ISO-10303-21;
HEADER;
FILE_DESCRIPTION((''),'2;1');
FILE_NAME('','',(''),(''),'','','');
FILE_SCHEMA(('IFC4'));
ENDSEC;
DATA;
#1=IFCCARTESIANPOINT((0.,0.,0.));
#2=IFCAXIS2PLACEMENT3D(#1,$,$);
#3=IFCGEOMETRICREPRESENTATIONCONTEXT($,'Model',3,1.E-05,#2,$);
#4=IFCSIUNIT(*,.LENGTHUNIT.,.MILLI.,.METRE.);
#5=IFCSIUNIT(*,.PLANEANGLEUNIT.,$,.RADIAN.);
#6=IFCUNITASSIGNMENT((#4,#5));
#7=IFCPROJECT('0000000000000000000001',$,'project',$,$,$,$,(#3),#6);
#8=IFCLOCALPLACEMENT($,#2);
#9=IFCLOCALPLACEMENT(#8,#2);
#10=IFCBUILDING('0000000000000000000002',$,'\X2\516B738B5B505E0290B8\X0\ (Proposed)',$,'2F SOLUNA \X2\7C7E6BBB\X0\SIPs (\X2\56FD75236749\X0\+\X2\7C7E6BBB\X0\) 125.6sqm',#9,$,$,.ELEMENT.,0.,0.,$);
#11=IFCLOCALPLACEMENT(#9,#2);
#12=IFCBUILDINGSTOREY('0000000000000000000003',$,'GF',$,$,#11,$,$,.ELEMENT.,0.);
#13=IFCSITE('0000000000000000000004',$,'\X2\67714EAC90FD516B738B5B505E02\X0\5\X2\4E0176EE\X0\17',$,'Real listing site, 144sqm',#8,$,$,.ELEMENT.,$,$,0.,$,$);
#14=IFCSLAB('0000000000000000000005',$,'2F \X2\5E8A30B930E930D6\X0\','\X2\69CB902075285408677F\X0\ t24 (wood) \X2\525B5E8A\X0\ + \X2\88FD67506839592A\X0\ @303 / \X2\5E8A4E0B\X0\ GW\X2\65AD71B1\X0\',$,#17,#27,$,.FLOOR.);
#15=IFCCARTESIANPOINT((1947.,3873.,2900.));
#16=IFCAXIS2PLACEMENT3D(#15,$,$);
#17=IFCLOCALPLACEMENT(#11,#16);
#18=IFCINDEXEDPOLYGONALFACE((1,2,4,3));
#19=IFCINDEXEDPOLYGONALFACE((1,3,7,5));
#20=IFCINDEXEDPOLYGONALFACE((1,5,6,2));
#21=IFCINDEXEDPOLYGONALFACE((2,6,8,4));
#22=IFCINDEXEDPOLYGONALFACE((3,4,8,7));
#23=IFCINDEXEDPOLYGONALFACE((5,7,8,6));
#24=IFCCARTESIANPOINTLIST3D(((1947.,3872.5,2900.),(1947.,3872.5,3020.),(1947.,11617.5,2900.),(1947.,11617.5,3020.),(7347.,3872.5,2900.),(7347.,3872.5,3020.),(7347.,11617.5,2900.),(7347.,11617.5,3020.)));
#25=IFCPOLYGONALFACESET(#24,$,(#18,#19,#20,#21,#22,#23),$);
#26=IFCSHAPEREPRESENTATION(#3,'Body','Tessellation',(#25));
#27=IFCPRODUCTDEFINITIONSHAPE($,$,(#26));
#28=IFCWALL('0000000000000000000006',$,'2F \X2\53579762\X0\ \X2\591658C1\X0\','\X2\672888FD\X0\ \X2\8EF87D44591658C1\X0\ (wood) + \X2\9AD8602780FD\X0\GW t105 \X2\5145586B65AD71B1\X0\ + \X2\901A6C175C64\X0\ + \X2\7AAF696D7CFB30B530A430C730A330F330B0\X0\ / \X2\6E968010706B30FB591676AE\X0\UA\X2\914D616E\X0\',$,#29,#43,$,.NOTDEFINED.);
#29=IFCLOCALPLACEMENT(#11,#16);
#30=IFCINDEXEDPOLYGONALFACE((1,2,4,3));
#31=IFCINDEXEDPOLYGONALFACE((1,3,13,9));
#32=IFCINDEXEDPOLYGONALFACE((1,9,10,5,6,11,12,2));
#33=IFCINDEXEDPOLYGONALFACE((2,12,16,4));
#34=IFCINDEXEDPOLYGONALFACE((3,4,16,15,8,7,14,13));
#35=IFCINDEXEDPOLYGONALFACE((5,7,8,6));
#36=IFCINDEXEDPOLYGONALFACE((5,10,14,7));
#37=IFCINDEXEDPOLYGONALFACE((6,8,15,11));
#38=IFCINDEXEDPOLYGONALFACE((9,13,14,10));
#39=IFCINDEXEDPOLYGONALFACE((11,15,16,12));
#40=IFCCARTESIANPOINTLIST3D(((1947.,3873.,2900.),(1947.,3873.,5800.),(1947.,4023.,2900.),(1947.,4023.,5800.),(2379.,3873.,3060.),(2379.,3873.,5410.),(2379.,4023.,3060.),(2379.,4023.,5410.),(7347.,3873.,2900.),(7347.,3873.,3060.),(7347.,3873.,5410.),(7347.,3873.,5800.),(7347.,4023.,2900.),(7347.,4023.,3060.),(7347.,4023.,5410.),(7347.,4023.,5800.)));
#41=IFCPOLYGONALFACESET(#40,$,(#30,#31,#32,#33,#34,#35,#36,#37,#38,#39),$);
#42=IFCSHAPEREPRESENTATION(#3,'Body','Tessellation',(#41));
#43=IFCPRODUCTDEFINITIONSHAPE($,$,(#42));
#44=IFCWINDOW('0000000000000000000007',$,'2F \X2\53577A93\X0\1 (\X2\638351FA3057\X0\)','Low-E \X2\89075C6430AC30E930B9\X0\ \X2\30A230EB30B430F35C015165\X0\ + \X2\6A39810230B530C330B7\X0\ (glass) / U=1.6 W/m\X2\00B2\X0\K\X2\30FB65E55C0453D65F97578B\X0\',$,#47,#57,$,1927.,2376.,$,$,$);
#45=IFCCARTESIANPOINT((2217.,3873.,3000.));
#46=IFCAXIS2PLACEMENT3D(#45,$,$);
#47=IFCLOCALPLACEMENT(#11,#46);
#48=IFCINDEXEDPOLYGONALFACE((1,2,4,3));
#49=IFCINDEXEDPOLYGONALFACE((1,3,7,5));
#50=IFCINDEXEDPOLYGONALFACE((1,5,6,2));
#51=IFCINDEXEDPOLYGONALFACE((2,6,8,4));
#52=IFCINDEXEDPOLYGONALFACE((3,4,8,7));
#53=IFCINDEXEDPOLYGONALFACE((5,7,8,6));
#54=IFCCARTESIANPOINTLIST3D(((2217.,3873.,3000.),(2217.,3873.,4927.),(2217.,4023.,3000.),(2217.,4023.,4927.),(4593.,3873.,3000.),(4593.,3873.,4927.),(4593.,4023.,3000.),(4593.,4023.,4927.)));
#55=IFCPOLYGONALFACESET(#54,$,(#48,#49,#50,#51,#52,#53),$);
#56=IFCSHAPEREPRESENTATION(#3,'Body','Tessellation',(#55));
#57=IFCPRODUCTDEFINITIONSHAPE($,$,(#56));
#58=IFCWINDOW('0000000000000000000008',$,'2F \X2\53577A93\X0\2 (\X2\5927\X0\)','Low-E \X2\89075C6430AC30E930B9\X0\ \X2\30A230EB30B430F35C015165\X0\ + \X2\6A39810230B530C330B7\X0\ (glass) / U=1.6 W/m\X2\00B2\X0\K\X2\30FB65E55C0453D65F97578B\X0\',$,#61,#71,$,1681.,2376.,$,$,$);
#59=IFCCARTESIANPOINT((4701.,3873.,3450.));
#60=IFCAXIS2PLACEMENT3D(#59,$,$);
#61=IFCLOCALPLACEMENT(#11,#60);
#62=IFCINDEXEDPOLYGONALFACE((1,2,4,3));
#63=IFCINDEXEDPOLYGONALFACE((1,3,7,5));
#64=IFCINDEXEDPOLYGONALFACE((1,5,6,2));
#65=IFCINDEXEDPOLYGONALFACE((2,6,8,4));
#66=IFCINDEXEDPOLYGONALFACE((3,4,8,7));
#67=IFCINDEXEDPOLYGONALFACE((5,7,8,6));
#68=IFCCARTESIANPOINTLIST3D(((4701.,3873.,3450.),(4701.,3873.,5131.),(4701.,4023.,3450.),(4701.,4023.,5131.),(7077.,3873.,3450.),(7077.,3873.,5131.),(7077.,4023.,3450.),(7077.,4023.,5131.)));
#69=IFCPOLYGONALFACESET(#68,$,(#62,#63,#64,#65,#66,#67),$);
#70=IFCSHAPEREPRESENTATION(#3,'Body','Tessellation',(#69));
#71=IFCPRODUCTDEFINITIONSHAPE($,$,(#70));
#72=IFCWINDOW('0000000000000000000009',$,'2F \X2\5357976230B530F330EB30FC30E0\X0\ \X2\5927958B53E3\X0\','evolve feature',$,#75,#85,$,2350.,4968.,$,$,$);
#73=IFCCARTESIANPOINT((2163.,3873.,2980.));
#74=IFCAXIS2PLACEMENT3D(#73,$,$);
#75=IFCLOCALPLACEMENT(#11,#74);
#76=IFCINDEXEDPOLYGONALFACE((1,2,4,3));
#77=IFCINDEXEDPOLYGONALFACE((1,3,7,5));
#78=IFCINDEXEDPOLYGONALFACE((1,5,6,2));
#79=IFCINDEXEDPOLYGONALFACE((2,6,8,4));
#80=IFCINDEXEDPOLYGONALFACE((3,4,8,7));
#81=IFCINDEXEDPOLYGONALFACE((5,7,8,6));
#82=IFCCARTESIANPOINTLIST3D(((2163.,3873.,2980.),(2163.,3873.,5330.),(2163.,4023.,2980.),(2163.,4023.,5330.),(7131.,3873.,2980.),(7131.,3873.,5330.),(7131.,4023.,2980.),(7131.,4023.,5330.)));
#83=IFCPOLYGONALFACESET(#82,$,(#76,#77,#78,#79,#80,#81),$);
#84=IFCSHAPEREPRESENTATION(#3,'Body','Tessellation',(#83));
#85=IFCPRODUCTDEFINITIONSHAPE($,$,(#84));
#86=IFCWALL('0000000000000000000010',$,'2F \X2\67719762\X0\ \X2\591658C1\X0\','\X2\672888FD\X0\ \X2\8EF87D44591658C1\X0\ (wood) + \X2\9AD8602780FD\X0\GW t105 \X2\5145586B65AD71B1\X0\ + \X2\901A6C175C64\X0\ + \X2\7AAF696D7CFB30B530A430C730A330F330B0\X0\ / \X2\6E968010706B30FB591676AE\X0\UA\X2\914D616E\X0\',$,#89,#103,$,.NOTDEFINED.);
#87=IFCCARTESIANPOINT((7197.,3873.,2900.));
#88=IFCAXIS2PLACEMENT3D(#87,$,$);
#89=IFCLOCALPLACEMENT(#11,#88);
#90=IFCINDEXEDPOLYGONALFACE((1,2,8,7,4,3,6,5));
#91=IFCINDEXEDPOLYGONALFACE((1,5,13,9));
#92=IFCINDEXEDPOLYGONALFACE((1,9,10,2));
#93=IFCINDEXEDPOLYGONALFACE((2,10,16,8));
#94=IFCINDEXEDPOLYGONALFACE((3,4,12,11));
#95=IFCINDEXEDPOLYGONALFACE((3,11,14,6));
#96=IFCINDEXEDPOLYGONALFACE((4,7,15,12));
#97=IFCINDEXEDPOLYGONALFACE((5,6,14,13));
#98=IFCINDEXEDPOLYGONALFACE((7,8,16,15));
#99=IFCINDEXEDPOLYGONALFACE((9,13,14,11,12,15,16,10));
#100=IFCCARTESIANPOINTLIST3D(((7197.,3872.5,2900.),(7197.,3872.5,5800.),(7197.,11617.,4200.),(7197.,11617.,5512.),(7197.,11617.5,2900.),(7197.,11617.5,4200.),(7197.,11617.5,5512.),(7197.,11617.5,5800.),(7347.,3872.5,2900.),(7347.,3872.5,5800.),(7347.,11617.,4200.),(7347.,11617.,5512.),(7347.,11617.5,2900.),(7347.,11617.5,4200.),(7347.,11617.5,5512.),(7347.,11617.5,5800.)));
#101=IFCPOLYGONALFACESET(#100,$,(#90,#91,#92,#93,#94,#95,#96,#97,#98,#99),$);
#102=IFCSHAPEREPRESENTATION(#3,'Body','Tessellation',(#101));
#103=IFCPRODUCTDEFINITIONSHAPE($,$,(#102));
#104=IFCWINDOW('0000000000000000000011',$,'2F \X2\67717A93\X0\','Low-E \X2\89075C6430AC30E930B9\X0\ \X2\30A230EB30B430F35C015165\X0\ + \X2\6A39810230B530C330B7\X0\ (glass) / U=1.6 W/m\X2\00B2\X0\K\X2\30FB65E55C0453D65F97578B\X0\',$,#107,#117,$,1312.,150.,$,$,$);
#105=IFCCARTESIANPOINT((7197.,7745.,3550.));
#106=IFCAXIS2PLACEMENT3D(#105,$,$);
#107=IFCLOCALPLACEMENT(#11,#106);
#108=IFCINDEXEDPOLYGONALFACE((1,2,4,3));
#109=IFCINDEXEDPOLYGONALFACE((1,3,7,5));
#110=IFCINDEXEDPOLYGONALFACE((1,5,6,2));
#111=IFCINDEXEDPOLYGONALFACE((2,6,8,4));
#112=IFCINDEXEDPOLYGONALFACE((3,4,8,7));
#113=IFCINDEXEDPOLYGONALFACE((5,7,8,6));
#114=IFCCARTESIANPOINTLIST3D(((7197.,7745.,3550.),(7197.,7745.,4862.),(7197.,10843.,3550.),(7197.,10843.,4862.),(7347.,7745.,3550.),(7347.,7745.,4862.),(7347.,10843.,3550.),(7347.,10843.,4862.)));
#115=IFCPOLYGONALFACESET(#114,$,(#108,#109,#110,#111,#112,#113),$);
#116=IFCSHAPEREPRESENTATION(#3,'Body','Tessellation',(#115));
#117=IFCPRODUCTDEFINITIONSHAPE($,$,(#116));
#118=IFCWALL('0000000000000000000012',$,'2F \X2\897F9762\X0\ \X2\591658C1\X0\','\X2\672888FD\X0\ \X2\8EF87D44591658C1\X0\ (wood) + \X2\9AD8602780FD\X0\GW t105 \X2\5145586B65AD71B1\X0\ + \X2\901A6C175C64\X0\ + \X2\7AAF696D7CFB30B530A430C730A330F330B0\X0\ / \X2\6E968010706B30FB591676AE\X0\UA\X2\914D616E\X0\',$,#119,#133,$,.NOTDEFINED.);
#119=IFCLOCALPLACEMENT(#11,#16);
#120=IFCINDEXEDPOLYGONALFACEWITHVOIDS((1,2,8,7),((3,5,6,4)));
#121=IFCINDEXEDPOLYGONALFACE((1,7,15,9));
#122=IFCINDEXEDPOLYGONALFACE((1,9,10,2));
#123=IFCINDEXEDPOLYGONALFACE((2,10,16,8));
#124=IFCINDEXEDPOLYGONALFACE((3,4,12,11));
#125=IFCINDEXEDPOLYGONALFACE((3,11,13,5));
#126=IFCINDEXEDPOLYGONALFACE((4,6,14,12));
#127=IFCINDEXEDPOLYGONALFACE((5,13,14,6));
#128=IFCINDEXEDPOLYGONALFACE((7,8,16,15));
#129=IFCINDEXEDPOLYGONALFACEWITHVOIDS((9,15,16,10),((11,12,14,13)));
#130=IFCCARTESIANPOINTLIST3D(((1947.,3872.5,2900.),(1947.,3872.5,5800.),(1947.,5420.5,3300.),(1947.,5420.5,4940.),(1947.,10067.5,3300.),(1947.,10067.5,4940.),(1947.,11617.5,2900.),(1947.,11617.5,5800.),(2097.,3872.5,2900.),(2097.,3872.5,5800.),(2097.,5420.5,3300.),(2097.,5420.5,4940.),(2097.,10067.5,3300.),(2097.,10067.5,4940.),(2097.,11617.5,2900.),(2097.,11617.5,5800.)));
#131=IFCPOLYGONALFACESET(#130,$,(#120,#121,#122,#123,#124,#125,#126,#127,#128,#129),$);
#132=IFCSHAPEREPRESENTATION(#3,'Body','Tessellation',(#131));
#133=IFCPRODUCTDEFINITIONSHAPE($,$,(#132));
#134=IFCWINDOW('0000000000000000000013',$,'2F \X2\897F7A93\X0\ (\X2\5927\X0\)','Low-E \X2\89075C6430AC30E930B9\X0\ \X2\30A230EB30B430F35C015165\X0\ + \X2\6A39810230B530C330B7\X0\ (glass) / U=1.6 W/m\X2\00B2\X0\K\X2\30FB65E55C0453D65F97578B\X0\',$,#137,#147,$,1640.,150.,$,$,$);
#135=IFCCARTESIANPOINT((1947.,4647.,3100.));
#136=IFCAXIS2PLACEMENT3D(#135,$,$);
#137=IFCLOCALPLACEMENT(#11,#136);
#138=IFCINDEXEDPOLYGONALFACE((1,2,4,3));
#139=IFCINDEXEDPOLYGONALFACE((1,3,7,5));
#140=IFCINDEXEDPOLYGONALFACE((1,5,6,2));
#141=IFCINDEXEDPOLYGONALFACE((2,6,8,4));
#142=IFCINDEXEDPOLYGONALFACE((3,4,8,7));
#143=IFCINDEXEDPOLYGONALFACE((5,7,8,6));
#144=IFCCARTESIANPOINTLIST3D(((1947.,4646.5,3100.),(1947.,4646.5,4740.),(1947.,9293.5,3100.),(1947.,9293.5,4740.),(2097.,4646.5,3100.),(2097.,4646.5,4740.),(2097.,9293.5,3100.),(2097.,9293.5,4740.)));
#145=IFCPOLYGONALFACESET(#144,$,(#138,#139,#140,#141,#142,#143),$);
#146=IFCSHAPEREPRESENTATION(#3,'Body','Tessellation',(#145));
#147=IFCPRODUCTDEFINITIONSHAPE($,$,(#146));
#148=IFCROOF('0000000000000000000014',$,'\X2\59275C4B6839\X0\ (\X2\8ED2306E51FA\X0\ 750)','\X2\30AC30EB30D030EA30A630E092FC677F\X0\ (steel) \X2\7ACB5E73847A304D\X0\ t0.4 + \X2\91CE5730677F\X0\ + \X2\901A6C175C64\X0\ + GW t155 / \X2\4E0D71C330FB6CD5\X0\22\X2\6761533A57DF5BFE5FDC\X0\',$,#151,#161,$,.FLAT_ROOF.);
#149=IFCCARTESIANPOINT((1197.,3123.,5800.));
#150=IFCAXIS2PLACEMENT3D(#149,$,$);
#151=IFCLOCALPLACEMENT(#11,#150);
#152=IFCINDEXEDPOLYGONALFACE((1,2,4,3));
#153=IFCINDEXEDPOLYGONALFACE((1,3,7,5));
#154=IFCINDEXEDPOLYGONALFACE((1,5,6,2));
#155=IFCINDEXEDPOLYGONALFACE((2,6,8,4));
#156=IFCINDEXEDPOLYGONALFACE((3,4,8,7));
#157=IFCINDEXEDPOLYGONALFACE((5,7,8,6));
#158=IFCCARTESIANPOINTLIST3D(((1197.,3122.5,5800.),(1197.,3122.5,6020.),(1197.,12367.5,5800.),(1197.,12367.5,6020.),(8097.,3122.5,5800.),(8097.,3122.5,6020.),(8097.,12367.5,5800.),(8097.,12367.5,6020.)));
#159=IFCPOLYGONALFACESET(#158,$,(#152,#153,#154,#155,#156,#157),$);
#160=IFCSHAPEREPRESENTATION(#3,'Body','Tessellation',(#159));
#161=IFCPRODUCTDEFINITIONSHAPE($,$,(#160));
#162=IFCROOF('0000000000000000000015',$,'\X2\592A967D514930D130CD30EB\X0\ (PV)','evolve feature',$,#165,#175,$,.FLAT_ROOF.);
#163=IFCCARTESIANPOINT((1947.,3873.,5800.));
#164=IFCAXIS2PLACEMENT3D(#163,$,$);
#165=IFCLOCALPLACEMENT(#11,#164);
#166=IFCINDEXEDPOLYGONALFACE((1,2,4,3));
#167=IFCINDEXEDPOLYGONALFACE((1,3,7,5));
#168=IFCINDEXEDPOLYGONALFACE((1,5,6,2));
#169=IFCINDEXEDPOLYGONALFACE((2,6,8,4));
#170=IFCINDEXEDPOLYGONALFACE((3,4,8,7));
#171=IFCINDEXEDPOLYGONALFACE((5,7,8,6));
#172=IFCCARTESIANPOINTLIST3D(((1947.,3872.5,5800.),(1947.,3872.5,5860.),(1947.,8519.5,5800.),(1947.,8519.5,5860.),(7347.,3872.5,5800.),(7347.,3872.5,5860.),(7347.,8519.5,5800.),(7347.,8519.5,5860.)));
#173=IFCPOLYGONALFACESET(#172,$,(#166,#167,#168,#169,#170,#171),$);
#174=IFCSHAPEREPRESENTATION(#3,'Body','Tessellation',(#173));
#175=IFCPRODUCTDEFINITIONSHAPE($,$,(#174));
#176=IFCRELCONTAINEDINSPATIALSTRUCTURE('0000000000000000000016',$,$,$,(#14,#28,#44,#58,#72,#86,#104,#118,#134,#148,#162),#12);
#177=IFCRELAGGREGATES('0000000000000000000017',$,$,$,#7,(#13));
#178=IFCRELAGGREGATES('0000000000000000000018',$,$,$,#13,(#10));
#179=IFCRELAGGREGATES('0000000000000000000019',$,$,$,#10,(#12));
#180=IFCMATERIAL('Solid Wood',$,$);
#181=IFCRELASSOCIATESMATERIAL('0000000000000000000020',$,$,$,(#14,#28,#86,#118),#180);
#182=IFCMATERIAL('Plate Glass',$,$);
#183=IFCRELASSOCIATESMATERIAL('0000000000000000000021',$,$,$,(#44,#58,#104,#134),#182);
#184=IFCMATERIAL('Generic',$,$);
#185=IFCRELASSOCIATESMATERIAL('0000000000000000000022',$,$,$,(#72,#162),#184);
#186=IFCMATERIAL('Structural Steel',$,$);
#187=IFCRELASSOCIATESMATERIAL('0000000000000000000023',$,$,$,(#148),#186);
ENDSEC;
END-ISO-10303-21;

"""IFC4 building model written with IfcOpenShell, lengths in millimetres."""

from ifc_helpers import new_model, si_unit, frame, frame_2d, origin, place, context, project, spatial, rectangle, extrude, material, element, fill, save


model = new_model("IFC4")

# Units and contexts
model_context = context("Model", 3, precision=1e-05, world=origin())
ifc_project = project(units=[si_unit("LENGTHUNIT", "METRE", prefix="MILLI"), si_unit("PLANEANGLEUNIT", "RADIAN")], contexts=[model_context])

# Site, building, storey
site_placement = place(None, origin())
site = spatial("IfcSite", under=ifc_project, at=site_placement, Name="東京都八王子市5丁目17", ObjectType="Real listing site, 144sqm", CompositionType="ELEMENT", RefElevation=0.0)
building_placement = place(site_placement, origin())
building = spatial("IfcBuilding", under=site, at=building_placement, Name="八王子市邸 (Proposed)", ObjectType="2F SOLUNA 籾殻SIPs (国産杉+籾殻) 125.6sqm", CompositionType="ELEMENT", ElevationOfRefHeight=0.0, ElevationOfTerrain=0.0)
storey_placement = place(building_placement, origin())
storey = spatial("IfcBuildingStorey", under=building, at=storey_placement, Name="GF", CompositionType="ELEMENT", Elevation=0.0)

# Slab
ifc_material_1 = material(Name="Solid Wood")
slab_placement = place(storey_placement, frame((1947.0, 3873.0, 2900.0)))
element("IfcSlab", 1, at=slab_placement, inside=storey, material=ifc_material_1, Name="2F 床スラブ", Description="構造用合板 t24 (wood) 剛床 + 製材根太 @303 / 床下 GW断熱", PredefinedType="FLOOR", context=model_context, shape_type="SweptSolid", body=[
    extrude(rectangle(XDim=5400.0, YDim=7745.0, at=frame_2d((2700.0, 3872.0))), frame((1947.0, 3873.0, 2900.0)), (0.0, 0.0, 1.0), 120.0),
])

# Wall, openings, windows
wall_1_placement = place(storey_placement, frame((1947.0, 3873.0, 2900.0)))
wall_1 = element("IfcWall", 2, at=wall_1_placement, inside=storey, material=ifc_material_1, Name="2F 南面 外壁", Description="木製 軸組外壁 (wood) + 高性能GW t105 充填断熱 + 通気層 + 窯業系サイディング / 準耐火・外皮UA配慮", PredefinedType="NOTDEFINED", context=model_context, shape_type="SweptSolid", body=[
    extrude(rectangle(XDim=5400.0, YDim=150.0, at=frame_2d((2700.0, 75.0))), frame((1947.0, 3873.0, 2900.0)), (0.0, 0.0, 1.0), 2900.0),
])
opening_1_placement = place(storey_placement, frame((2217.0, 3873.0, 3000.0)))
opening_1 = element("IfcOpeningElement", 3, at=opening_1_placement, cuts=wall_1, PredefinedType="NOTDEFINED", context=model_context, shape_type="SweptSolid", body=[
    extrude(rectangle(XDim=2376.0, YDim=150.0, at=frame_2d((1188.0, 75.0))), frame((2217.0, 3873.0, 3000.0)), (0.0, 0.0, 1.0), 1927.0),
])
opening_2_placement = place(storey_placement, frame((4701.0, 3873.0, 3450.0)))
opening_2 = element("IfcOpeningElement", 4, at=opening_2_placement, cuts=wall_1, PredefinedType="NOTDEFINED", context=model_context, shape_type="SweptSolid", body=[
    extrude(rectangle(XDim=2376.0, YDim=150.0, at=frame_2d((1188.0, 75.0))), frame((4701.0, 3873.0, 3450.0)), (0.0, 0.0, 1.0), 1681.0),
])
opening_3_placement = place(storey_placement, frame((2163.0, 3873.0, 2980.0)))
opening_3 = element("IfcOpeningElement", 5, at=opening_3_placement, cuts=wall_1, PredefinedType="NOTDEFINED", context=model_context, shape_type="SweptSolid", body=[
    extrude(rectangle(XDim=4968.0, YDim=150.0, at=frame_2d((2484.0, 75.0))), frame((2163.0, 3873.0, 2980.0)), (0.0, 0.0, 1.0), 2350.0),
])
ifc_material_2 = material(Name="Plate Glass")
window_1_placement = place(storey_placement, frame((2217.0, 3873.0, 3000.0)))
window_1 = element("IfcWindow", 6, at=window_1_placement, inside=storey, material=ifc_material_2, Name="2F 南窓1 (掃出し)", Description="Low-E 複層ガラス アルゴン封入 + 樹脂サッシ (glass) / U=1.6 W/m²K・日射取得型", OverallHeight=1927.0, OverallWidth=2376.0, context=model_context, shape_type="SweptSolid", body=[
    extrude(rectangle(XDim=2376.0, YDim=150.0, at=frame_2d((1188.0, 75.0))), frame((2217.0, 3873.0, 3000.0)), (0.0, 0.0, 1.0), 1927.0),
])
fill(opening_1, window_1)
window_2_placement = place(storey_placement, frame((4701.0, 3873.0, 3450.0)))
window_2 = element("IfcWindow", 7, at=window_2_placement, inside=storey, material=ifc_material_2, Name="2F 南窓2 (大)", Description="Low-E 複層ガラス アルゴン封入 + 樹脂サッシ (glass) / U=1.6 W/m²K・日射取得型", OverallHeight=1681.0, OverallWidth=2376.0, context=model_context, shape_type="SweptSolid", body=[
    extrude(rectangle(XDim=2376.0, YDim=150.0, at=frame_2d((1188.0, 75.0))), frame((4701.0, 3873.0, 3450.0)), (0.0, 0.0, 1.0), 1681.0),
])
fill(opening_2, window_2)
ifc_material_3 = material(Name="Generic")
window_3_placement = place(storey_placement, frame((2163.0, 3873.0, 2980.0)))
window_3 = element("IfcWindow", 8, at=window_3_placement, inside=storey, material=ifc_material_3, Name="2F 南面サンルーム 大開口", Description="evolve feature", OverallHeight=2350.0, OverallWidth=4968.0, context=model_context, shape_type="SweptSolid", body=[
    extrude(rectangle(XDim=4968.0, YDim=150.0, at=frame_2d((2484.0, 75.0))), frame((2163.0, 3873.0, 2980.0)), (0.0, 0.0, 1.0), 2350.0),
])
fill(opening_3, window_3)

# Walls, openings, windows
wall_2_placement = place(storey_placement, frame((7197.0, 3873.0, 2900.0)))
wall_2 = element("IfcWall", 9, at=wall_2_placement, inside=storey, material=ifc_material_1, Name="2F 東面 外壁", Description="木製 軸組外壁 (wood) + 高性能GW t105 充填断熱 + 通気層 + 窯業系サイディング / 準耐火・外皮UA配慮", PredefinedType="NOTDEFINED", context=model_context, shape_type="SweptSolid", body=[
    extrude(rectangle(XDim=150.0, YDim=7745.0, at=frame_2d((75.0, 3872.0))), frame((7197.0, 3873.0, 2900.0)), (0.0, 0.0, 1.0), 2900.0),
])
opening_4_placement = place(storey_placement, frame((7197.0, 7745.0, 3550.0)))
opening_4 = element("IfcOpeningElement", 10, at=opening_4_placement, cuts=wall_2, PredefinedType="NOTDEFINED", context=model_context, shape_type="SweptSolid", body=[
    extrude(rectangle(XDim=150.0, YDim=3098.0, at=frame_2d((75.0, 1549.0))), frame((7197.0, 7745.0, 3550.0)), (0.0, 0.0, 1.0), 1312.0),
])
window_4_placement = place(storey_placement, frame((7197.0, 7745.0, 3550.0)))
window_4 = element("IfcWindow", 11, at=window_4_placement, inside=storey, material=ifc_material_2, Name="2F 東窓", Description="Low-E 複層ガラス アルゴン封入 + 樹脂サッシ (glass) / U=1.6 W/m²K・日射取得型", OverallHeight=1312.0, OverallWidth=150.0, context=model_context, shape_type="SweptSolid", body=[
    extrude(rectangle(XDim=150.0, YDim=3098.0, at=frame_2d((75.0, 1549.0))), frame((7197.0, 7745.0, 3550.0)), (0.0, 0.0, 1.0), 1312.0),
])
fill(opening_4, window_4)
wall_3_placement = place(storey_placement, frame((1947.0, 3873.0, 2900.0)))
wall_3 = element("IfcWall", 12, at=wall_3_placement, inside=storey, material=ifc_material_1, Name="2F 西面 外壁", Description="木製 軸組外壁 (wood) + 高性能GW t105 充填断熱 + 通気層 + 窯業系サイディング / 準耐火・外皮UA配慮", PredefinedType="NOTDEFINED", context=model_context, shape_type="SweptSolid", body=[
    extrude(rectangle(XDim=150.0, YDim=7745.0, at=frame_2d((75.0, 3872.0))), frame((1947.0, 3873.0, 2900.0)), (0.0, 0.0, 1.0), 2900.0),
])
opening_5_placement = place(storey_placement, frame((1947.0, 4647.0, 3100.0)))
opening_5 = element("IfcOpeningElement", 13, at=opening_5_placement, cuts=wall_3, PredefinedType="NOTDEFINED", context=model_context, shape_type="SweptSolid", body=[
    extrude(rectangle(XDim=150.0, YDim=4647.0, at=frame_2d((75.0, 2323.0))), frame((1947.0, 4647.0, 3100.0)), (0.0, 0.0, 1.0), 1640.0),
])
window_5_placement = place(storey_placement, frame((1947.0, 4647.0, 3100.0)))
window_5 = element("IfcWindow", 14, at=window_5_placement, inside=storey, material=ifc_material_2, Name="2F 西窓 (大)", Description="Low-E 複層ガラス アルゴン封入 + 樹脂サッシ (glass) / U=1.6 W/m²K・日射取得型", OverallHeight=1640.0, OverallWidth=150.0, context=model_context, shape_type="SweptSolid", body=[
    extrude(rectangle(XDim=150.0, YDim=4647.0, at=frame_2d((75.0, 2323.0))), frame((1947.0, 4647.0, 3100.0)), (0.0, 0.0, 1.0), 1640.0),
])
fill(opening_5, window_5)

# Roofs
ifc_material_4 = material(Name="Structural Steel")
roof_1_placement = place(storey_placement, frame((1197.0, 3123.0, 5800.0)))
element("IfcRoof", 15, at=roof_1_placement, inside=storey, material=ifc_material_4, Name="大屋根 (軒の出 750)", Description="ガルバリウム鋼板 (steel) 立平葺き t0.4 + 野地板 + 通気層 + GW t155 / 不燃・法22条区域対応", PredefinedType="FLAT_ROOF", context=model_context, shape_type="SweptSolid", body=[
    extrude(rectangle(XDim=6900.0, YDim=9245.0, at=frame_2d((3450.0, 4622.0))), frame((1197.0, 3123.0, 5800.0)), (0.0, 0.0, 1.0), 220.0),
])
roof_2_placement = place(storey_placement, frame((1947.0, 3873.0, 5800.0)))
element("IfcRoof", 16, at=roof_2_placement, inside=storey, material=ifc_material_3, Name="太陽光パネル (PV)", Description="evolve feature", PredefinedType="FLAT_ROOF", context=model_context, shape_type="SweptSolid", body=[
    extrude(rectangle(XDim=5400.0, YDim=4647.0, at=frame_2d((2700.0, 2323.0))), frame((1947.0, 3873.0, 5800.0)), (0.0, 0.0, 1.0), 60.0),
])

save(model, "model.ifc")
